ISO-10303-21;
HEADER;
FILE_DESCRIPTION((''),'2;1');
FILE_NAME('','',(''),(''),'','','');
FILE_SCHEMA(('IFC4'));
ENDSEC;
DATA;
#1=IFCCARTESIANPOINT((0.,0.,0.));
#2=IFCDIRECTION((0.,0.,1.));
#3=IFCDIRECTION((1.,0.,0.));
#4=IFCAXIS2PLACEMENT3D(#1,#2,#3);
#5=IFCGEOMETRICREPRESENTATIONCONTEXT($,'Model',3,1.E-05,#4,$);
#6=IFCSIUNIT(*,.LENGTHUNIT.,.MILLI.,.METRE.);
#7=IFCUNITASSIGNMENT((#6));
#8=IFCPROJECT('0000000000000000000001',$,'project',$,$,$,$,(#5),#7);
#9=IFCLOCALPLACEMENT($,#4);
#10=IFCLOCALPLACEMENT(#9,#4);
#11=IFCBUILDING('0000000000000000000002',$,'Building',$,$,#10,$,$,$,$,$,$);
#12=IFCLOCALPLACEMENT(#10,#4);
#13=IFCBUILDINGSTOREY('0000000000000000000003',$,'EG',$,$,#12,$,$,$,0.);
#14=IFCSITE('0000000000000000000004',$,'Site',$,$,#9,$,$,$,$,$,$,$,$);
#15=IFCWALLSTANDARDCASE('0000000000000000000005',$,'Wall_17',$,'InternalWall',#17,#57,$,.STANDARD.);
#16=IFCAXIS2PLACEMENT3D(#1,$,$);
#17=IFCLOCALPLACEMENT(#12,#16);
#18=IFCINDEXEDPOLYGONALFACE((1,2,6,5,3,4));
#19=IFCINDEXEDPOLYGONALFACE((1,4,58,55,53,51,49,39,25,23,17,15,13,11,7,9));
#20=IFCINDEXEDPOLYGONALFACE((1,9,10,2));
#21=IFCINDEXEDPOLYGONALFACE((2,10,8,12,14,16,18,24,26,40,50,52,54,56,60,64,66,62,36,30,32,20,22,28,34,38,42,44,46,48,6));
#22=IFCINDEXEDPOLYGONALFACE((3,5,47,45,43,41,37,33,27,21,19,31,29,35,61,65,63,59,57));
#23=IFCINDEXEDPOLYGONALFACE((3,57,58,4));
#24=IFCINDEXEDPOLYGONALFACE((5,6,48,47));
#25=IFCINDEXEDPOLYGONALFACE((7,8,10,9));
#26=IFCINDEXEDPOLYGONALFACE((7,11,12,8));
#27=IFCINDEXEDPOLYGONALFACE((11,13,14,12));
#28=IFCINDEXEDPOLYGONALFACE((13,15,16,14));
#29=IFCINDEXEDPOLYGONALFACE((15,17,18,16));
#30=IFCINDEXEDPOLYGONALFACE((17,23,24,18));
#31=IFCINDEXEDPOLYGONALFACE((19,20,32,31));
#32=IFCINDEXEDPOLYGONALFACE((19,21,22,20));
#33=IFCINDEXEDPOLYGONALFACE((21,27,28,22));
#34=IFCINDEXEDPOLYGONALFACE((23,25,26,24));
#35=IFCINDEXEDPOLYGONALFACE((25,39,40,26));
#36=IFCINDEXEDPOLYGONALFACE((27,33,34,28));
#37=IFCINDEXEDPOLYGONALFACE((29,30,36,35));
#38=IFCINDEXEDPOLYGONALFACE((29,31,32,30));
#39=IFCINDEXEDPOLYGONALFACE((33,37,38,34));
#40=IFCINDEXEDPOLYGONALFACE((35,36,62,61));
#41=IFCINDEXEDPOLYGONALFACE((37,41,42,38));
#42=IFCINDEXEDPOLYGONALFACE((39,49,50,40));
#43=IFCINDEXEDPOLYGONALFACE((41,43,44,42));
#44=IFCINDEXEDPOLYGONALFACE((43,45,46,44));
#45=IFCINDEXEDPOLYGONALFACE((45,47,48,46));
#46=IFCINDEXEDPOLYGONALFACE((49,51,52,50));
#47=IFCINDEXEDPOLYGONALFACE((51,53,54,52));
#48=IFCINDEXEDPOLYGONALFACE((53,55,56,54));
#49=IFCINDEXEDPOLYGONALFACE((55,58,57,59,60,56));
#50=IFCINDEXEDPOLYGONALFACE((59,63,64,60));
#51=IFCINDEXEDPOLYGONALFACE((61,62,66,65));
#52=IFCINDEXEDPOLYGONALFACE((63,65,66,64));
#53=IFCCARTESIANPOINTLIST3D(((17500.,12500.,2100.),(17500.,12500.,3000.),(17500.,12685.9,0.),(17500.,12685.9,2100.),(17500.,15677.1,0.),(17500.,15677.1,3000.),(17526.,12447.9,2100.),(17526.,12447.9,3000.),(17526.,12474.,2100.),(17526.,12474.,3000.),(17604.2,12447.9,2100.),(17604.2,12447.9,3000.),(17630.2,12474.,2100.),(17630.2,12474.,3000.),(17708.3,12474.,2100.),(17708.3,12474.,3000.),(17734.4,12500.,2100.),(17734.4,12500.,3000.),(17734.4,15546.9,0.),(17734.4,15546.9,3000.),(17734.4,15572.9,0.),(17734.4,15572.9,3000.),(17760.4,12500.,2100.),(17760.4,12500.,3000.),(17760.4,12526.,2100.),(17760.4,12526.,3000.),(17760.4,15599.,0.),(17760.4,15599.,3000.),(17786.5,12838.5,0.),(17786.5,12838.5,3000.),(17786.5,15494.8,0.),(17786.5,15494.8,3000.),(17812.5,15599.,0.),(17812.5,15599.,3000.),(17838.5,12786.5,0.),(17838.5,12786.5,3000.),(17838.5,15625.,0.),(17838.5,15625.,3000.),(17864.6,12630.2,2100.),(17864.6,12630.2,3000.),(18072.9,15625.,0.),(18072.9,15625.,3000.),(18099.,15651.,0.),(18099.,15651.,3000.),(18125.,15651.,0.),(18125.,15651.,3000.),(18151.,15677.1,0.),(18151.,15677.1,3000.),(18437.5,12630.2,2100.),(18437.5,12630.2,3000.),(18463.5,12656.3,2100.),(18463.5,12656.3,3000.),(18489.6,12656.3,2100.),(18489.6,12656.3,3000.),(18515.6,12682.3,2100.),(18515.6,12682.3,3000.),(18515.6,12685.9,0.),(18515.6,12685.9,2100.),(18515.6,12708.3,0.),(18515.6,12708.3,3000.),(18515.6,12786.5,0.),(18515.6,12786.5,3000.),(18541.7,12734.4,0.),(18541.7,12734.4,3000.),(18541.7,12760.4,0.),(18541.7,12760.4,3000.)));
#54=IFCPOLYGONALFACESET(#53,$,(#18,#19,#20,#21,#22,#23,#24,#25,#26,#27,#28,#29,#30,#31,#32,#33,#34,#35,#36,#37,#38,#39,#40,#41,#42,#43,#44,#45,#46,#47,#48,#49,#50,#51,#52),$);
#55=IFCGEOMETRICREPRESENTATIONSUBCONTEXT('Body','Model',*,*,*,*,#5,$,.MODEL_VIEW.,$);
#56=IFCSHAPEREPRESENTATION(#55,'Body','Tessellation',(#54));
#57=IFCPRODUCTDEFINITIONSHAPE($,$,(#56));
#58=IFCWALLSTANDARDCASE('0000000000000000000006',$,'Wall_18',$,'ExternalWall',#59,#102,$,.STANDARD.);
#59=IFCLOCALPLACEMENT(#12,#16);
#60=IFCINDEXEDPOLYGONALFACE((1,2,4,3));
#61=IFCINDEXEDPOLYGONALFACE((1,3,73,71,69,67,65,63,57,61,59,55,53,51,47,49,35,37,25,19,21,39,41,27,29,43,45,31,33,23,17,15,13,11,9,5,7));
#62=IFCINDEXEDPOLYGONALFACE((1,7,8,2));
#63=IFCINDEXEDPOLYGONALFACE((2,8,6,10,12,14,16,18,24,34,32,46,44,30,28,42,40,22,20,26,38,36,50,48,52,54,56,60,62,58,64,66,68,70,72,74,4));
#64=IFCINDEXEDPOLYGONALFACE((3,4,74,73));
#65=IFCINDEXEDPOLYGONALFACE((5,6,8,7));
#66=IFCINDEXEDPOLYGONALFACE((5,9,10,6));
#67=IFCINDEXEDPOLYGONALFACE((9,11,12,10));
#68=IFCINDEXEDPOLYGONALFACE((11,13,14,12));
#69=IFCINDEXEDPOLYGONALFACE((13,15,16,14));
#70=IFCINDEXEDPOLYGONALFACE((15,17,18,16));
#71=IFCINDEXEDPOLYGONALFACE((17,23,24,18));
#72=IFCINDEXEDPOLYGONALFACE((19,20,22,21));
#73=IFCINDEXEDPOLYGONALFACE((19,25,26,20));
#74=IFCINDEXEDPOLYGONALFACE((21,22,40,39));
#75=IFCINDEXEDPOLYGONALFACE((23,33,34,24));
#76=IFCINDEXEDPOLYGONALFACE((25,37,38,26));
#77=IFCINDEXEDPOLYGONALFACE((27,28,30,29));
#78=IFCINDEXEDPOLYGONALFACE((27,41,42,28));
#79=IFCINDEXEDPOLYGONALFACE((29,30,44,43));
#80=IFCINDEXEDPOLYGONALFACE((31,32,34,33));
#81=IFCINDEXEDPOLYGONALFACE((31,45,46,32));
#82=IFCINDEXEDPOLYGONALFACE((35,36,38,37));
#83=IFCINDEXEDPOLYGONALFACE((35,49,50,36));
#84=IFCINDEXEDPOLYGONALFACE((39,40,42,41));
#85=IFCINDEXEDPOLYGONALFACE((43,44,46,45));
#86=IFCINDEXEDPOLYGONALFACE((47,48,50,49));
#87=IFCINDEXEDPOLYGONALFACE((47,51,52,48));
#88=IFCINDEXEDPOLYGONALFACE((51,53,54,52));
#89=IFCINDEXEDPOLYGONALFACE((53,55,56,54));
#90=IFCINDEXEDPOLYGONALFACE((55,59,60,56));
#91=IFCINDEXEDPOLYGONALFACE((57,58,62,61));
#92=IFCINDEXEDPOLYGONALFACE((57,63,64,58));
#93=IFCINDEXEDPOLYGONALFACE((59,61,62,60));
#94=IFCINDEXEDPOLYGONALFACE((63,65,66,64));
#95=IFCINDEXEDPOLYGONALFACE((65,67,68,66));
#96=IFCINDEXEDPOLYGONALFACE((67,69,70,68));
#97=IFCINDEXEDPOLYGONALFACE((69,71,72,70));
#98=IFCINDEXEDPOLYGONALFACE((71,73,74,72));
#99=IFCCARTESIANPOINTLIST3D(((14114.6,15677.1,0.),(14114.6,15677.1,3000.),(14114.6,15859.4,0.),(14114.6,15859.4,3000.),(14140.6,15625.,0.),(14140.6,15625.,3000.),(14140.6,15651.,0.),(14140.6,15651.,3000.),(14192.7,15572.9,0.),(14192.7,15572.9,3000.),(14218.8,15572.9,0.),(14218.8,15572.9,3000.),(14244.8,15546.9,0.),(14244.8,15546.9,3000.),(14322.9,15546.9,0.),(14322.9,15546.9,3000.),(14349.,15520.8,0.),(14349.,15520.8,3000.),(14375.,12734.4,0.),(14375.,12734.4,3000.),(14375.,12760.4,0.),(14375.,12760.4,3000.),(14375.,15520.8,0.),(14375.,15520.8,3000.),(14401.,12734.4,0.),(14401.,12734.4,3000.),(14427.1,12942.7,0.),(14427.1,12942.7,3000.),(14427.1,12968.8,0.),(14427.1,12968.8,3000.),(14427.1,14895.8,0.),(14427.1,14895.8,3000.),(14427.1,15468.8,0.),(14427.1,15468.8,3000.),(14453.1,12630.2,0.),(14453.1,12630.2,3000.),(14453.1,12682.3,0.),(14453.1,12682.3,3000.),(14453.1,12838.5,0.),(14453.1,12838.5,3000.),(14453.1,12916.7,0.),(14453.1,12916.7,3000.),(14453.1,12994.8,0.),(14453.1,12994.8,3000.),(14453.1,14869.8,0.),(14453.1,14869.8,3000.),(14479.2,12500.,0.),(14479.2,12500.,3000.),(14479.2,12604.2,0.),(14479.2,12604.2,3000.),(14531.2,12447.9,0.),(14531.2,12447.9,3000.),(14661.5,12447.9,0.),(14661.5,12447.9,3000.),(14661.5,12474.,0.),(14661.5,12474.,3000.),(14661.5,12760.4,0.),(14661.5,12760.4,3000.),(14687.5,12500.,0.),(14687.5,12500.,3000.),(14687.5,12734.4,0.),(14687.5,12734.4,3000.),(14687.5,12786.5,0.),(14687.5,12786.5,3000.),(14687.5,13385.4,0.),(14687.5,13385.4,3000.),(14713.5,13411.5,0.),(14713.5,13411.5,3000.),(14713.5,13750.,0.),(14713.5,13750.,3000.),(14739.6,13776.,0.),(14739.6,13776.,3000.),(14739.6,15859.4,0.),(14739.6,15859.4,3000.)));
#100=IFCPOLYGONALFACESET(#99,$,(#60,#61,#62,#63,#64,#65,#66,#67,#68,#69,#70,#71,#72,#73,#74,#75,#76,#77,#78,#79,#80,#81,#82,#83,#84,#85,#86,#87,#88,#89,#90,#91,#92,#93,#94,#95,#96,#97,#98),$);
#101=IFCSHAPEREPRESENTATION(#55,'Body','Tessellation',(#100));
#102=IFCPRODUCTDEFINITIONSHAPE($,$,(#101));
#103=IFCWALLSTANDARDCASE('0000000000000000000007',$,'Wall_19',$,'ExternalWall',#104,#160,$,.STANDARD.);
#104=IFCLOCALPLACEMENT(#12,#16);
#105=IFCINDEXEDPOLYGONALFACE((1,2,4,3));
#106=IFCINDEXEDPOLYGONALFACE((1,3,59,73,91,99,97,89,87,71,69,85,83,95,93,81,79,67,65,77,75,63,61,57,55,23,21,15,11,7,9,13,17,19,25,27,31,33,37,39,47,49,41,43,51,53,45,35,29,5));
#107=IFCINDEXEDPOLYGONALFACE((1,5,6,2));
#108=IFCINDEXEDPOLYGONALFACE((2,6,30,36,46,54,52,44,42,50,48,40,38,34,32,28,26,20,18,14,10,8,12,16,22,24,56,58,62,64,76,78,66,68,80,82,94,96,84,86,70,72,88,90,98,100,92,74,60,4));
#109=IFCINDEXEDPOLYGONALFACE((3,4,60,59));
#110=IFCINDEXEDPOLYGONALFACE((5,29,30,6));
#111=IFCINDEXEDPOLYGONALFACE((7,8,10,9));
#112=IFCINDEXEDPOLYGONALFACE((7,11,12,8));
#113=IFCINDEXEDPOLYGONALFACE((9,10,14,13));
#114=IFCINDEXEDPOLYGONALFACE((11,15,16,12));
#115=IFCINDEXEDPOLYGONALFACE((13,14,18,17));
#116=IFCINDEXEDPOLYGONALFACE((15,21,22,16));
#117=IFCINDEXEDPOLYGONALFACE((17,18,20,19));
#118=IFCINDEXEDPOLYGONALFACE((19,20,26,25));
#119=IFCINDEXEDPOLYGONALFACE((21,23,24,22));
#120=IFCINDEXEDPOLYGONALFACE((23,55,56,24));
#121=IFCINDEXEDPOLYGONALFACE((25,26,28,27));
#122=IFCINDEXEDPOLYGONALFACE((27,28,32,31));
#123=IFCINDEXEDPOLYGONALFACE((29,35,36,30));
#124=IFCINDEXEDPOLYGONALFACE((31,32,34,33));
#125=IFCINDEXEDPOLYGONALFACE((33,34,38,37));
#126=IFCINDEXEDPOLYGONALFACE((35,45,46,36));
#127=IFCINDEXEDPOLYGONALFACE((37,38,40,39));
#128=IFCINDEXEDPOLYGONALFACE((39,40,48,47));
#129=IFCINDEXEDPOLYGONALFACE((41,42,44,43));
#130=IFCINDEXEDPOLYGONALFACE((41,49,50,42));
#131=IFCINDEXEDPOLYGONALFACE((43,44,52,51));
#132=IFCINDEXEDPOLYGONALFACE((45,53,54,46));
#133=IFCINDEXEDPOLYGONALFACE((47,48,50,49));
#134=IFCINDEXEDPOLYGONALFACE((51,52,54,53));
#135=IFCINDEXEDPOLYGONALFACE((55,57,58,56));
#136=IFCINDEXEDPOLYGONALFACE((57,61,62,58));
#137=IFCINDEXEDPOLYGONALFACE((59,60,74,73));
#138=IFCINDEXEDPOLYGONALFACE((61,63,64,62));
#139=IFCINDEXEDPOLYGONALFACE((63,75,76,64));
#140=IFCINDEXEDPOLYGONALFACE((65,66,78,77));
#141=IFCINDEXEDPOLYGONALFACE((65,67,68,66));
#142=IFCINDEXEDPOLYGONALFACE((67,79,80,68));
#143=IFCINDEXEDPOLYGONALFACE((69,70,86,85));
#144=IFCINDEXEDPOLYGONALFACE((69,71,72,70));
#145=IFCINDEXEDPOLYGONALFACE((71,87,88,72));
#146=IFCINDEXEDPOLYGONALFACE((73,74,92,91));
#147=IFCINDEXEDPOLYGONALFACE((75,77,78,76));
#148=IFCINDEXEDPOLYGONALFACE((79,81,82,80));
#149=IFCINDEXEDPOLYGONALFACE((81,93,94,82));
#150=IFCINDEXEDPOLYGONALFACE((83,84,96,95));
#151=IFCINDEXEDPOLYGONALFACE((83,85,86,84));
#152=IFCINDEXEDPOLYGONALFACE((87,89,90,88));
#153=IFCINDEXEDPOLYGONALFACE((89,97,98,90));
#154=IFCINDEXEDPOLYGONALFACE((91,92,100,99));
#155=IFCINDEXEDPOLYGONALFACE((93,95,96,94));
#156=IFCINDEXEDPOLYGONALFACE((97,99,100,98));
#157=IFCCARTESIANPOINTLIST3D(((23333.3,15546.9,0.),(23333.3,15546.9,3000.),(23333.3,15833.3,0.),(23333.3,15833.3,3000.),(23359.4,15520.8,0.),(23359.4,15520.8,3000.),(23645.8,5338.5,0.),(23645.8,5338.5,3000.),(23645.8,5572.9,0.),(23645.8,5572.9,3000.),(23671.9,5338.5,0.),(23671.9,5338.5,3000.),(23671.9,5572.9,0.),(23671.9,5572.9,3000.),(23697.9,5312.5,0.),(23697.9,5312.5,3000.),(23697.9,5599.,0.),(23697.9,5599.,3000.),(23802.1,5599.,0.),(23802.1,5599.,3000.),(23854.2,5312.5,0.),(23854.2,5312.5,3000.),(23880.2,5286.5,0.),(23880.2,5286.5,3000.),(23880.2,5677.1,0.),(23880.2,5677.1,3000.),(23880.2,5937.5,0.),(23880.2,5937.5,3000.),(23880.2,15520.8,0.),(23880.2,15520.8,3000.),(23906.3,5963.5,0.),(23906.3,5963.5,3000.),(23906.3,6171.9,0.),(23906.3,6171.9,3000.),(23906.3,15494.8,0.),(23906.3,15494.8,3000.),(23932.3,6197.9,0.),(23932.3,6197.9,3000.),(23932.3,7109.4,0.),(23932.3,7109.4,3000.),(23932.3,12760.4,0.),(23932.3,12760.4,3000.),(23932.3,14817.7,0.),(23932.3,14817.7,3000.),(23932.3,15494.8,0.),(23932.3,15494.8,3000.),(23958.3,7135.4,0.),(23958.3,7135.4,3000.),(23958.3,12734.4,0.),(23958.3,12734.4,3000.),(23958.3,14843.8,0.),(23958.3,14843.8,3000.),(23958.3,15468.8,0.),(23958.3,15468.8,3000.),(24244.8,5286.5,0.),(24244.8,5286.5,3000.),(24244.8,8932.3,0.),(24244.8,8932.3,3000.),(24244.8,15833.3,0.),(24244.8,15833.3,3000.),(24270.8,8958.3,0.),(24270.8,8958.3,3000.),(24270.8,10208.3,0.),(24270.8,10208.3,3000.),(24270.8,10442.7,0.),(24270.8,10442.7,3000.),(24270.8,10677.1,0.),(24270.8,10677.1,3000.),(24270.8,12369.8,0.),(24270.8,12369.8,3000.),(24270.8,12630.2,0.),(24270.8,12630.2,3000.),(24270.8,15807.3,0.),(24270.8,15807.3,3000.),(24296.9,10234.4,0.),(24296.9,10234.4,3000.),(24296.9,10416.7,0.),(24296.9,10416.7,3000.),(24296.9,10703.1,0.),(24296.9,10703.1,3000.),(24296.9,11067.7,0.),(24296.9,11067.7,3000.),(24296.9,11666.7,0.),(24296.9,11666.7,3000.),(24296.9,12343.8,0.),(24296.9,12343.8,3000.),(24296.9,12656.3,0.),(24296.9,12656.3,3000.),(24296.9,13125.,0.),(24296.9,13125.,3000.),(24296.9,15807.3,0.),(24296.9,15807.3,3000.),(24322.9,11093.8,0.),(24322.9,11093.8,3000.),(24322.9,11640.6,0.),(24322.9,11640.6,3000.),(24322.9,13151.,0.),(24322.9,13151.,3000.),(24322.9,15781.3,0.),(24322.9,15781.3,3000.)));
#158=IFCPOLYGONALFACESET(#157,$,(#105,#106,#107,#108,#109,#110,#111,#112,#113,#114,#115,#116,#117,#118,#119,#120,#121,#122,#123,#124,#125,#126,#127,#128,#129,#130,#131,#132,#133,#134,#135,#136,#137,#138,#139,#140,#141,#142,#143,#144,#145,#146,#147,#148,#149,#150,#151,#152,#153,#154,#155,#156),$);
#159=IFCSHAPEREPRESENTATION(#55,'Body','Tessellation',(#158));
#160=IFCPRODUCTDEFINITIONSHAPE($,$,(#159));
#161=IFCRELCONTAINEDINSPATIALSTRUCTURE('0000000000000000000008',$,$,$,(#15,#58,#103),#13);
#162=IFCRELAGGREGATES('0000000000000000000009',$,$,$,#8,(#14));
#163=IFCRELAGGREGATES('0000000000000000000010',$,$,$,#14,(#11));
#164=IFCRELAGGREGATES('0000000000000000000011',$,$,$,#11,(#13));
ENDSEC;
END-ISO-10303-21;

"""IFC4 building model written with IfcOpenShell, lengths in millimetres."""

from ifc_helpers import new_model, si_unit, frame, origin_with_axes, place, context, subcontext, project, spatial, polyline, rectangle, outline, extrude, element, save


model = new_model("IFC4")

# Units and contexts
model_context = context("Model", 3, precision=1e-05, world=origin_with_axes())
body_context = subcontext(model_context, "Body", "Model", "MODEL_VIEW")
ifc_project = project(units=[si_unit("LENGTHUNIT", "METRE", prefix="MILLI")], contexts=[model_context])

# Site, building, storey
site_placement = place(None, origin_with_axes())
site = spatial("IfcSite", under=ifc_project, at=site_placement, Name="Site")
building_placement = place(site_placement, origin_with_axes())
building = spatial("IfcBuilding", under=site, at=building_placement, Name="Building")
storey_placement = place(building_placement, origin_with_axes())
storey = spatial("IfcBuildingStorey", under=building, at=storey_placement, Name="EG", Elevation=0.0)

# Walls, openings
wall_1_placement = place(storey_placement, origin_with_axes())
wall_1 = element("IfcWallStandardCase", 1, at=wall_1_placement, inside=storey, Name="Wall_17", ObjectType="InternalWall", PredefinedType="STANDARD", context=body_context, shape_type="SweptSolid", body=[
    extrude(outline(polyline([(17526.0, 12447.9, 0.0), (17526.0, 12474.0, 0.0), (17500.0, 12500.0, 0.0), (17500.0, 15677.1, 0.0), (18151.0, 15677.1, 0.0), (18125.0, 15651.0, 0.0), (18099.0, 15651.0, 0.0), (18072.9, 15625.0, 0.0), (17838.5, 15625.0, 0.0), (17812.5, 15599.0, 0.0), (17760.4, 15599.0, 0.0), (17734.4, 15572.9, 0.0), (17734.4, 15546.9, 0.0), (17786.5, 15494.8, 0.0), (17786.5, 12838.5, 0.0), (17838.5, 12786.5, 0.0), (18515.6, 12786.5, 0.0), (18541.7, 12760.4, 0.0), (18541.7, 12734.4, 0.0), (18515.6, 12708.3, 0.0), (18515.6, 12682.3, 0.0), (18489.6, 12656.3, 0.0), (18463.5, 12656.3, 0.0), (18437.5, 12630.2, 0.0), (17864.6, 12630.2, 0.0), (17760.4, 12526.0, 0.0), (17760.4, 12500.0, 0.0), (17734.4, 12500.0, 0.0), (17708.3, 12474.0, 0.0), (17630.2, 12474.0, 0.0), (17604.2, 12447.9, 0.0), (17526.0, 12447.9, 0.0)])), origin_with_axes(), (0.0, 0.0, 1.0), 3000.0),
])
opening_1_placement = place(wall_1_placement, origin_with_axes())
element("IfcOpeningElement", 2, at=opening_1_placement, inside=storey, cuts=wall_1, context=body_context, shape_type="SweptSolid", body=[
    extrude(rectangle(XDim=450.0, YDim=1041.7), frame((18020.8, 12460.9, 0.0), z_axis=(0.0, 0.0, 1.0), x_axis=(0.0, 1.0, 0.0)), (0.0, 0.0, 1.0), 2100.0),
])
wall_2_placement = place(storey_placement, origin_with_axes())
wall_2 = element("IfcWallStandardCase", 3, at=wall_2_placement, inside=storey, Name="Wall_18", ObjectType="ExternalWall", PredefinedType="STANDARD", context=body_context, shape_type="SweptSolid", body=[
    extrude(outline(polyline([(14531.2, 12447.9, 0.0), (14479.2, 12500.0, 0.0), (14479.2, 12604.2, 0.0), (14453.1, 12630.2, 0.0), (14453.1, 12682.3, 0.0), (14401.0, 12734.4, 0.0), (14375.0, 12734.4, 0.0), (14375.0, 12760.4, 0.0), (14453.1, 12838.5, 0.0), (14453.1, 12916.7, 0.0), (14427.1, 12942.7, 0.0), (14427.1, 12968.8, 0.0), (14453.1, 12994.8, 0.0), (14453.1, 14869.8, 0.0), (14427.1, 14895.8, 0.0), (14427.1, 15468.8, 0.0), (14375.0, 15520.8, 0.0), (14349.0, 15520.8, 0.0), (14322.9, 15546.9, 0.0), (14244.8, 15546.9, 0.0), (14218.8, 15572.9, 0.0), (14192.7, 15572.9, 0.0), (14140.6, 15625.0, 0.0), (14140.6, 15651.0, 0.0), (14114.6, 15677.1, 0.0), (14114.6, 15859.4, 0.0), (14739.6, 15859.4, 0.0), (14739.6, 13776.0, 0.0), (14713.5, 13750.0, 0.0), (14713.5, 13411.5, 0.0), (14687.5, 13385.4, 0.0), (14687.5, 12786.5, 0.0), (14661.5, 12760.4, 0.0), (14687.5, 12734.4, 0.0), (14687.5, 12500.0, 0.0), (14661.5, 12474.0, 0.0), (14661.5, 12447.9, 0.0), (14531.2, 12447.9, 0.0)])), origin_with_axes(), (0.0, 0.0, 1.0), 3000.0),
])
opening_2_placement = place(wall_2_placement, origin_with_axes())
element("IfcOpeningElement", 4, at=opening_2_placement, inside=storey, cuts=wall_2, context=body_context, shape_type="SweptSolid", body=[
    extrude(rectangle(XDim=900.0, YDim=625.0), frame((14301.5, 11982.3, 0.0), z_axis=(0.0, 0.0, 1.0), x_axis=(0.0, 1.0, 0.0)), (0.0, 0.0, 1.0), 2100.0),
])

# Wall
wall_3_placement = place(storey_placement, origin_with_axes())
element("IfcWallStandardCase", 5, at=wall_3_placement, inside=storey, Name="Wall_19", ObjectType="ExternalWall", PredefinedType="STANDARD", context=body_context, shape_type="SweptSolid", body=[
    extrude(outline(polyline([(23880.2, 5286.5, 0.0), (23854.2, 5312.5, 0.0), (23697.9, 5312.5, 0.0), (23671.9, 5338.5, 0.0), (23645.8, 5338.5, 0.0), (23645.8, 5572.9, 0.0), (23671.9, 5572.9, 0.0), (23697.9, 5599.0, 0.0), (23802.1, 5599.0, 0.0), (23880.2, 5677.1, 0.0), (23880.2, 5937.5, 0.0), (23906.3, 5963.5, 0.0), (23906.3, 6171.9, 0.0), (23932.3, 6197.9, 0.0), (23932.3, 7109.4, 0.0), (23958.3, 7135.4, 0.0), (23958.3, 12734.4, 0.0), (23932.3, 12760.4, 0.0), (23932.3, 14817.7, 0.0), (23958.3, 14843.8, 0.0), (23958.3, 15468.8, 0.0), (23932.3, 15494.8, 0.0), (23906.3, 15494.8, 0.0), (23880.2, 15520.8, 0.0), (23359.4, 15520.8, 0.0), (23333.3, 15546.9, 0.0), (23333.3, 15833.3, 0.0), (24244.8, 15833.3, 0.0), (24270.8, 15807.3, 0.0), (24296.9, 15807.3, 0.0), (24322.9, 15781.3, 0.0), (24322.9, 13151.0, 0.0), (24296.9, 13125.0, 0.0), (24296.9, 12656.3, 0.0), (24270.8, 12630.2, 0.0), (24270.8, 12369.8, 0.0), (24296.9, 12343.8, 0.0), (24296.9, 11666.7, 0.0), (24322.9, 11640.6, 0.0), (24322.9, 11093.8, 0.0), (24296.9, 11067.7, 0.0), (24296.9, 10703.1, 0.0), (24270.8, 10677.1, 0.0), (24270.8, 10442.7, 0.0), (24296.9, 10416.7, 0.0), (24296.9, 10234.4, 0.0), (24270.8, 10208.3, 0.0), (24270.8, 8958.3, 0.0), (24244.8, 8932.3, 0.0), (24244.8, 5286.5, 0.0), (23880.2, 5286.5, 0.0)])), origin_with_axes(), (0.0, 0.0, 1.0), 3000.0),
])

save(model, "model.ifc")
